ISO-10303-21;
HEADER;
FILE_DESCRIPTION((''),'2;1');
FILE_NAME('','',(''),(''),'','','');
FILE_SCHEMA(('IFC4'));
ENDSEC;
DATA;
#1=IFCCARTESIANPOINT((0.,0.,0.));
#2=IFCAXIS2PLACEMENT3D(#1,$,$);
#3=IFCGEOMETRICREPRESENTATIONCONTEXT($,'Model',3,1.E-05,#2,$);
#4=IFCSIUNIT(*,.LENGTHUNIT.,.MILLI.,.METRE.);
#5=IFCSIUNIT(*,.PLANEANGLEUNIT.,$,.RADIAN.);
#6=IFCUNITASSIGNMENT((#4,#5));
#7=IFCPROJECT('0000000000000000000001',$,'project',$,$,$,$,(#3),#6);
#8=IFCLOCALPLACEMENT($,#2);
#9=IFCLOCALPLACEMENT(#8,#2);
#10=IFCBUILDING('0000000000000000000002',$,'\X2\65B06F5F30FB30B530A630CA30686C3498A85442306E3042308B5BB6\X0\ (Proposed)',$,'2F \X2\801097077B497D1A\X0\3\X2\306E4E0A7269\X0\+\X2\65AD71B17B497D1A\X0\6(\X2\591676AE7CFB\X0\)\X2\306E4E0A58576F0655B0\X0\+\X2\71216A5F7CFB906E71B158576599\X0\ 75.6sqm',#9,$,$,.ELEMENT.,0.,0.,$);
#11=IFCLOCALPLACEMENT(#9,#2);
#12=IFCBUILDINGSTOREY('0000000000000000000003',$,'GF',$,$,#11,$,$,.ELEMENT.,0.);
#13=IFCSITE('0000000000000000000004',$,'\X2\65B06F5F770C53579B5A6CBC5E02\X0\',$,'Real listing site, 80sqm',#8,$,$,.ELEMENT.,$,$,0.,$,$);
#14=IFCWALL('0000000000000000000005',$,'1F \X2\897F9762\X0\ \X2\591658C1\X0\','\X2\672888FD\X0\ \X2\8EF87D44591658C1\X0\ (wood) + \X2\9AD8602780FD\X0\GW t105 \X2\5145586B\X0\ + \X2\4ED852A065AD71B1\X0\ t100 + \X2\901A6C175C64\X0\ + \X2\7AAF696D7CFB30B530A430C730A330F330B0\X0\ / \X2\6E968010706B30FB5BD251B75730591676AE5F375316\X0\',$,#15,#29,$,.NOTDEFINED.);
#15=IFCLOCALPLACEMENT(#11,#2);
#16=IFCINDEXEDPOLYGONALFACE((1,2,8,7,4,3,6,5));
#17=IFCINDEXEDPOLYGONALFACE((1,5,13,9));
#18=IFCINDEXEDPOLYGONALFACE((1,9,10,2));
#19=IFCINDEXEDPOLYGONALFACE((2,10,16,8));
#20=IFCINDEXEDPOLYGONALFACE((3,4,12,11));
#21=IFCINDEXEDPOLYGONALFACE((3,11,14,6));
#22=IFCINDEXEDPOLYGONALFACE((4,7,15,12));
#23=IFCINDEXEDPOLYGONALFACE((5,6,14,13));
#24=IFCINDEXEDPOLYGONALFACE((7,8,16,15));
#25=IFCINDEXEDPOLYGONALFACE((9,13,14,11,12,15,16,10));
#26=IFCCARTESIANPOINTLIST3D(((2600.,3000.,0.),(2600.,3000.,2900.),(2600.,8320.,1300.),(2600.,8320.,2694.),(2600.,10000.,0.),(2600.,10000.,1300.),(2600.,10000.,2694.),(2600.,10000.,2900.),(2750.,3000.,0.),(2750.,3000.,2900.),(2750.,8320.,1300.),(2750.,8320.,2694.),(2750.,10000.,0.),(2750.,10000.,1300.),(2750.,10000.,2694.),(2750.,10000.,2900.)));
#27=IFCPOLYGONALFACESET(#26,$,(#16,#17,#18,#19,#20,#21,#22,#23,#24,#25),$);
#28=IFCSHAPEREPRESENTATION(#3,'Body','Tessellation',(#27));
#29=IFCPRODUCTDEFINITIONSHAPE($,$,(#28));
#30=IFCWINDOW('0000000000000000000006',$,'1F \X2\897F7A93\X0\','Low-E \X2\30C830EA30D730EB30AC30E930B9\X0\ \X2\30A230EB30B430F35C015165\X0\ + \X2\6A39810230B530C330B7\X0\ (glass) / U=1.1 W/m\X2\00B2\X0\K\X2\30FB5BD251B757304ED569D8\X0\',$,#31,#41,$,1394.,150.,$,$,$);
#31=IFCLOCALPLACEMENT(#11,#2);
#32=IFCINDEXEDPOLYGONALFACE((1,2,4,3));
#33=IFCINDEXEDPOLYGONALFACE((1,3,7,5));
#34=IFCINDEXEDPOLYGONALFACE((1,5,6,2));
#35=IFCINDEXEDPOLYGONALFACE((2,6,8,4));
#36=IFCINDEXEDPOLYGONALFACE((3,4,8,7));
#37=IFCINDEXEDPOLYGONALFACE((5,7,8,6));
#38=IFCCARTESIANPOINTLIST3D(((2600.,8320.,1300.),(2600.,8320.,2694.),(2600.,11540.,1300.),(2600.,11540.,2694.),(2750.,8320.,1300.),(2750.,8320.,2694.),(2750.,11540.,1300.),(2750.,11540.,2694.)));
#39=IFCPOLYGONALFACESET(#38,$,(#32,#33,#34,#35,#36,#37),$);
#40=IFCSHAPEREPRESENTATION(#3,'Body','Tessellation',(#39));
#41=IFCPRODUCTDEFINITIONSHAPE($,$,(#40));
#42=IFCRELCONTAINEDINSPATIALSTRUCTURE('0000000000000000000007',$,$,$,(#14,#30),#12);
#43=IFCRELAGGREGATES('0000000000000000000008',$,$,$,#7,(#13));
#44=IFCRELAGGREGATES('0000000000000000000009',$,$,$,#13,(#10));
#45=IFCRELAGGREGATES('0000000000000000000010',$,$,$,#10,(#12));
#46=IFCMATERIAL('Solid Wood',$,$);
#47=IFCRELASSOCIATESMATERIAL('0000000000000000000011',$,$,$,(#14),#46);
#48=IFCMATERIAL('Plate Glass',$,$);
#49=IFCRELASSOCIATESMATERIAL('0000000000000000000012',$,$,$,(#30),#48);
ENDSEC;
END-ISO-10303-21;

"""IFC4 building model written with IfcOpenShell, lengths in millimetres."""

from ifc_helpers import new_model, si_unit, frame, frame_2d, origin, place, context, project, spatial, rectangle, extrude, material, element, fill, save


model = new_model("IFC4")

# Units and contexts
model_context = context("Model", 3, precision=1e-05, world=origin())
ifc_project = project(units=[si_unit("LENGTHUNIT", "METRE", prefix="MILLI"), si_unit("PLANEANGLEUNIT", "RADIAN")], contexts=[model_context])

# Site, building, storey
site_placement = place(None, origin())
site = spatial("IfcSite", under=ifc_project, at=site_placement, Name="新潟県南魚沼市", ObjectType="Real listing site, 80sqm", CompositionType="ELEMENT", RefElevation=0.0)
building_placement = place(site_placement, origin())
building = spatial("IfcBuilding", under=site, at=building_placement, Name="新潟・サウナと水風呂のある家 (Proposed)", ObjectType="2F 耐震等級3の上物+断熱等級6(外皮系)の上塗漆喰+無機系遮熱塗料 75.6sqm", CompositionType="ELEMENT", ElevationOfRefHeight=0.0, ElevationOfTerrain=0.0)
storey_placement = place(building_placement, origin())
storey = spatial("IfcBuildingStorey", under=building, at=storey_placement, Name="GF", CompositionType="ELEMENT", Elevation=0.0)

# Shared definitions
ifc_material_1 = material(Name="Solid Wood")

# Shared definitions
ifc_material_2 = material(Name="Plate Glass")

# Wall, opening, window
wall_1_placement = place(storey_placement, frame((1300.0, 1500.0, 0.0)))
wall_1 = element("IfcWall", 1, at=wall_1_placement, inside=storey, material=ifc_material_1, Name="1F 西面 外壁", Description="木製 軸組外壁 (wood) + 高性能GW t105 充填 + 付加断熱 t100 + 通気層 + 窯業系サイディング / 準耐火・寒冷地外皮強化", PredefinedType="NOTDEFINED", context=model_context, shape_type="SweptSolid", body=[
    extrude(rectangle(XDim=150.0, YDim=7000.0, at=frame_2d((75.0, 3500.0))), frame((1300.0, 1500.0, 0.0)), (0.0, 0.0, 1.0), 2900.0),
])
opening_1_placement = place(storey_placement, frame((1300.0, 4160.0, 650.0)))
opening_1 = element("IfcOpeningElement", 2, at=opening_1_placement, cuts=wall_1, PredefinedType="NOTDEFINED", context=model_context, shape_type="SweptSolid", body=[
    extrude(rectangle(XDim=150.0, YDim=3220.0, at=frame_2d((75.0, 1610.0))), frame((1300.0, 4160.0, 650.0)), (0.0, 0.0, 1.0), 1394.0),
])
window_1_placement = place(storey_placement, frame((1300.0, 4160.0, 650.0)))
window_1 = element("IfcWindow", 3, at=window_1_placement, inside=storey, material=ifc_material_2, Name="1F 西窓", Description="Low-E トリプルガラス アルゴン封入 + 樹脂サッシ (glass) / U=1.1 W/m²K・寒冷地仕様", OverallHeight=1394.0, OverallWidth=150.0, context=model_context, shape_type="SweptSolid", body=[
    extrude(rectangle(XDim=150.0, YDim=3220.0, at=frame_2d((75.0, 1610.0))), frame((1300.0, 4160.0, 650.0)), (0.0, 0.0, 1.0), 1394.0),
])
fill(opening_1, window_1)

save(model, "model.ifc")
